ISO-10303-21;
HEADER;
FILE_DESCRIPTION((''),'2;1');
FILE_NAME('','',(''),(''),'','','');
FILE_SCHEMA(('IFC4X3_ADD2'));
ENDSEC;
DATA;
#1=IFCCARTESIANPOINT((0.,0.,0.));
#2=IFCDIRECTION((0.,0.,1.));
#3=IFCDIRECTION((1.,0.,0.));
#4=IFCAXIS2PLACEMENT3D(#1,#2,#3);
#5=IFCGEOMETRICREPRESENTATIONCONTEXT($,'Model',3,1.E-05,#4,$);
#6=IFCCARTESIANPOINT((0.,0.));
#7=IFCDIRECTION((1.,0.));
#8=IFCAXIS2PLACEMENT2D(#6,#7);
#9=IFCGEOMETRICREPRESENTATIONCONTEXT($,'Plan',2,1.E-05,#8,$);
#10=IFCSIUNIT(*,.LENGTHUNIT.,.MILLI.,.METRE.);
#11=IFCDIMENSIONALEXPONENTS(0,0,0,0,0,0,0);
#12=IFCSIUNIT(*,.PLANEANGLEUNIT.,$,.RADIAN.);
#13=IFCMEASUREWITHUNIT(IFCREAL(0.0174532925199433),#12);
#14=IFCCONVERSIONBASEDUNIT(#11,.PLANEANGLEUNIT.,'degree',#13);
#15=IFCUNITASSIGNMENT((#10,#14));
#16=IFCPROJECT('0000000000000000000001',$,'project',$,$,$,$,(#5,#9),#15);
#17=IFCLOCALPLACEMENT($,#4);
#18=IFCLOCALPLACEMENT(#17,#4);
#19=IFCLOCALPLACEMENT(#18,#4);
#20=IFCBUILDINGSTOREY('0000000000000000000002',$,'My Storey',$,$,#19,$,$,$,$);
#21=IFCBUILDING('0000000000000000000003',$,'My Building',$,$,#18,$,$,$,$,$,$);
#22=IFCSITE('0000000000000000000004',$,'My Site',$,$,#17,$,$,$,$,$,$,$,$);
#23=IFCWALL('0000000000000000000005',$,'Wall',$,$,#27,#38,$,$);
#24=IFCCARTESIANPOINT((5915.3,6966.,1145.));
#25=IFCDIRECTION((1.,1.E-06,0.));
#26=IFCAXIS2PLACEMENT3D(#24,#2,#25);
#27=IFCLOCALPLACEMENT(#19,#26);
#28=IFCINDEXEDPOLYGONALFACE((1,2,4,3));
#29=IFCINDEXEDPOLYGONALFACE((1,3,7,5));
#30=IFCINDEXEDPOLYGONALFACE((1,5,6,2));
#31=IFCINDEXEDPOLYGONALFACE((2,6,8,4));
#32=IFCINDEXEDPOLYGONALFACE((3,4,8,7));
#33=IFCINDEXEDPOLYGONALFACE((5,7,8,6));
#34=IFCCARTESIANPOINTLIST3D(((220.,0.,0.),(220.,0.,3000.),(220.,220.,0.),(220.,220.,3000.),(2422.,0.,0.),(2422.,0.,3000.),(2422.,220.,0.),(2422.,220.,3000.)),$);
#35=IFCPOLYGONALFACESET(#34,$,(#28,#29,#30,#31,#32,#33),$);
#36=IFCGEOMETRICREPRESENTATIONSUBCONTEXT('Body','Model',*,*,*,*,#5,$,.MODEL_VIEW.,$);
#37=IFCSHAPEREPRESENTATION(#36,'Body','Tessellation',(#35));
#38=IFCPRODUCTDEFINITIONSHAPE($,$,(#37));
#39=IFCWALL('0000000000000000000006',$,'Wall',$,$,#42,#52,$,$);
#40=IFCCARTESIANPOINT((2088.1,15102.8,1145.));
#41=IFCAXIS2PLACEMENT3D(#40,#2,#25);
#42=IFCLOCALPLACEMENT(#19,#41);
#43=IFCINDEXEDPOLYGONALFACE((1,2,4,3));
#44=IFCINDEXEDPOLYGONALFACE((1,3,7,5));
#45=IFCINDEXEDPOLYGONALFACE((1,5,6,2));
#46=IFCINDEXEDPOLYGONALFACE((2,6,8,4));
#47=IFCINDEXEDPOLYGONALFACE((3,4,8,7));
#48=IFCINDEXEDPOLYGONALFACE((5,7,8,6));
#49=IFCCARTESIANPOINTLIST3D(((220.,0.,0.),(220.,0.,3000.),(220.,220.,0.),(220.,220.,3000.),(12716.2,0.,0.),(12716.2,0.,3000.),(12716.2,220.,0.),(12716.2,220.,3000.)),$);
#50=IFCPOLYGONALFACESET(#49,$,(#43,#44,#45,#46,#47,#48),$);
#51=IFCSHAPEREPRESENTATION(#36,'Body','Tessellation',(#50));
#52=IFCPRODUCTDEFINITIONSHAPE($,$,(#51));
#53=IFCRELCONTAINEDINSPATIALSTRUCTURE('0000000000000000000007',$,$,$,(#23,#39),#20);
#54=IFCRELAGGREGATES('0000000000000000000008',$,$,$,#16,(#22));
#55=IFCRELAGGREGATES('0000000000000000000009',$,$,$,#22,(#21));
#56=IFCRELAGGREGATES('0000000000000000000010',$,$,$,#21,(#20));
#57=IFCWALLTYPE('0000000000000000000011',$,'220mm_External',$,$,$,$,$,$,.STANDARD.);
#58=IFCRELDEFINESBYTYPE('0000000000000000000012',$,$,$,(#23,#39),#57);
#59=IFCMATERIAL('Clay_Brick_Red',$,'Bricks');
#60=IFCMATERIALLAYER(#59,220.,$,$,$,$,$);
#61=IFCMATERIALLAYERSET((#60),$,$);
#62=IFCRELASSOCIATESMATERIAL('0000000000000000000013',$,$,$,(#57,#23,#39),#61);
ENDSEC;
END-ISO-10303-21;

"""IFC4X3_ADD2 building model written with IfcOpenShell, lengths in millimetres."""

from ifc_helpers import new_model, entity, si_unit, converted_unit, frame, origin_with_axes, origin_2d_with_axis, place, context, subcontext, project, spatial, line, indexed_curve, outline, extrude, material, layer, layer_set, layer_usage, type_object, element, save


model = new_model("IFC4X3_ADD2")

# Units and contexts
model_context = context("Model", 3, precision=1e-05, world=origin_with_axes())
plan_context = context("Plan", 2, precision=1e-05, world=origin_2d_with_axis())
body_context_1 = subcontext(model_context, "Body", "Model", "MODEL_VIEW")
ifc_project = project(units=[si_unit("LENGTHUNIT", "METRE", prefix="MILLI"), converted_unit("PLANEANGLEUNIT", "degree", entity("IfcReal", 0.0174532925199433), si_unit("PLANEANGLEUNIT", "RADIAN"), dimensions=[0, 0, 0, 0, 0, 0, 0])], contexts=[model_context, plan_context])

# Site, building, storey
site_placement = place(None, origin_with_axes())
site = spatial("IfcSite", under=ifc_project, at=site_placement, Name="My Site")
building_placement = place(site_placement, origin_with_axes())
building = spatial("IfcBuilding", under=site, at=building_placement, Name="My Building")
storey_placement = place(building_placement, origin_with_axes())
storey = spatial("IfcBuildingStorey", under=building, at=storey_placement, Name="My Storey")

# Wall
ifc_material_1 = material(Name="Clay_Brick_Red", Category="Bricks")
ifc_layer_1 = layer(ifc_material_1, 220.0)
ifc_layer_set_1 = layer_set([ifc_layer_1])
ifc_layer_usage_1 = layer_usage(ifc_layer_set_1, "AXIS2", "POSITIVE", 0.0)
wall_type_1 = type_object("IfcWallType", Name="220mm_External", PredefinedType="STANDARD", material=ifc_layer_set_1)
wall_1_placement = place(storey_placement, frame((5915.3, 6966.0, 1145.0), z_axis=(0.0, 0.0, 1.0), x_axis=(1.0, 0.000001, 0.0)))
element("IfcWall", 1, at=wall_1_placement, inside=storey, type_object=wall_type_1, material=ifc_layer_usage_1, Name="Wall", context=body_context_1, shape_type="SweptSolid", body=[
    extrude(outline(indexed_curve([(220.0, 0.0), (220.0, 220.0), (2422.0, 220.0), (2422.0, 0.0)], segments=[line(1, 2, 3, 4, 1)])), origin_with_axes(), (0.0, 0.0, 1.0), 3000.0),
])

# Wall
ifc_layer_usage_2 = layer_usage(ifc_layer_set_1, "AXIS2", "POSITIVE", 0.0)
wall_2_placement = place(storey_placement, frame((2088.1, 15102.8, 1145.0), z_axis=(0.0, 0.0, 1.0), x_axis=(1.0, 0.000001, 0.0)))
element("IfcWall", 2, at=wall_2_placement, inside=storey, type_object=wall_type_1, material=ifc_layer_usage_2, Name="Wall", context=body_context_1, shape_type="SweptSolid", body=[
    extrude(outline(indexed_curve([(220.0, 0.0), (220.0, 220.0), (12716.2, 220.0), (12716.2, 0.0)], segments=[line(1, 2, 3, 4, 1)])), origin_with_axes(), (0.0, 0.0, 1.0), 3000.0),
])

save(model, "model.ifc")
